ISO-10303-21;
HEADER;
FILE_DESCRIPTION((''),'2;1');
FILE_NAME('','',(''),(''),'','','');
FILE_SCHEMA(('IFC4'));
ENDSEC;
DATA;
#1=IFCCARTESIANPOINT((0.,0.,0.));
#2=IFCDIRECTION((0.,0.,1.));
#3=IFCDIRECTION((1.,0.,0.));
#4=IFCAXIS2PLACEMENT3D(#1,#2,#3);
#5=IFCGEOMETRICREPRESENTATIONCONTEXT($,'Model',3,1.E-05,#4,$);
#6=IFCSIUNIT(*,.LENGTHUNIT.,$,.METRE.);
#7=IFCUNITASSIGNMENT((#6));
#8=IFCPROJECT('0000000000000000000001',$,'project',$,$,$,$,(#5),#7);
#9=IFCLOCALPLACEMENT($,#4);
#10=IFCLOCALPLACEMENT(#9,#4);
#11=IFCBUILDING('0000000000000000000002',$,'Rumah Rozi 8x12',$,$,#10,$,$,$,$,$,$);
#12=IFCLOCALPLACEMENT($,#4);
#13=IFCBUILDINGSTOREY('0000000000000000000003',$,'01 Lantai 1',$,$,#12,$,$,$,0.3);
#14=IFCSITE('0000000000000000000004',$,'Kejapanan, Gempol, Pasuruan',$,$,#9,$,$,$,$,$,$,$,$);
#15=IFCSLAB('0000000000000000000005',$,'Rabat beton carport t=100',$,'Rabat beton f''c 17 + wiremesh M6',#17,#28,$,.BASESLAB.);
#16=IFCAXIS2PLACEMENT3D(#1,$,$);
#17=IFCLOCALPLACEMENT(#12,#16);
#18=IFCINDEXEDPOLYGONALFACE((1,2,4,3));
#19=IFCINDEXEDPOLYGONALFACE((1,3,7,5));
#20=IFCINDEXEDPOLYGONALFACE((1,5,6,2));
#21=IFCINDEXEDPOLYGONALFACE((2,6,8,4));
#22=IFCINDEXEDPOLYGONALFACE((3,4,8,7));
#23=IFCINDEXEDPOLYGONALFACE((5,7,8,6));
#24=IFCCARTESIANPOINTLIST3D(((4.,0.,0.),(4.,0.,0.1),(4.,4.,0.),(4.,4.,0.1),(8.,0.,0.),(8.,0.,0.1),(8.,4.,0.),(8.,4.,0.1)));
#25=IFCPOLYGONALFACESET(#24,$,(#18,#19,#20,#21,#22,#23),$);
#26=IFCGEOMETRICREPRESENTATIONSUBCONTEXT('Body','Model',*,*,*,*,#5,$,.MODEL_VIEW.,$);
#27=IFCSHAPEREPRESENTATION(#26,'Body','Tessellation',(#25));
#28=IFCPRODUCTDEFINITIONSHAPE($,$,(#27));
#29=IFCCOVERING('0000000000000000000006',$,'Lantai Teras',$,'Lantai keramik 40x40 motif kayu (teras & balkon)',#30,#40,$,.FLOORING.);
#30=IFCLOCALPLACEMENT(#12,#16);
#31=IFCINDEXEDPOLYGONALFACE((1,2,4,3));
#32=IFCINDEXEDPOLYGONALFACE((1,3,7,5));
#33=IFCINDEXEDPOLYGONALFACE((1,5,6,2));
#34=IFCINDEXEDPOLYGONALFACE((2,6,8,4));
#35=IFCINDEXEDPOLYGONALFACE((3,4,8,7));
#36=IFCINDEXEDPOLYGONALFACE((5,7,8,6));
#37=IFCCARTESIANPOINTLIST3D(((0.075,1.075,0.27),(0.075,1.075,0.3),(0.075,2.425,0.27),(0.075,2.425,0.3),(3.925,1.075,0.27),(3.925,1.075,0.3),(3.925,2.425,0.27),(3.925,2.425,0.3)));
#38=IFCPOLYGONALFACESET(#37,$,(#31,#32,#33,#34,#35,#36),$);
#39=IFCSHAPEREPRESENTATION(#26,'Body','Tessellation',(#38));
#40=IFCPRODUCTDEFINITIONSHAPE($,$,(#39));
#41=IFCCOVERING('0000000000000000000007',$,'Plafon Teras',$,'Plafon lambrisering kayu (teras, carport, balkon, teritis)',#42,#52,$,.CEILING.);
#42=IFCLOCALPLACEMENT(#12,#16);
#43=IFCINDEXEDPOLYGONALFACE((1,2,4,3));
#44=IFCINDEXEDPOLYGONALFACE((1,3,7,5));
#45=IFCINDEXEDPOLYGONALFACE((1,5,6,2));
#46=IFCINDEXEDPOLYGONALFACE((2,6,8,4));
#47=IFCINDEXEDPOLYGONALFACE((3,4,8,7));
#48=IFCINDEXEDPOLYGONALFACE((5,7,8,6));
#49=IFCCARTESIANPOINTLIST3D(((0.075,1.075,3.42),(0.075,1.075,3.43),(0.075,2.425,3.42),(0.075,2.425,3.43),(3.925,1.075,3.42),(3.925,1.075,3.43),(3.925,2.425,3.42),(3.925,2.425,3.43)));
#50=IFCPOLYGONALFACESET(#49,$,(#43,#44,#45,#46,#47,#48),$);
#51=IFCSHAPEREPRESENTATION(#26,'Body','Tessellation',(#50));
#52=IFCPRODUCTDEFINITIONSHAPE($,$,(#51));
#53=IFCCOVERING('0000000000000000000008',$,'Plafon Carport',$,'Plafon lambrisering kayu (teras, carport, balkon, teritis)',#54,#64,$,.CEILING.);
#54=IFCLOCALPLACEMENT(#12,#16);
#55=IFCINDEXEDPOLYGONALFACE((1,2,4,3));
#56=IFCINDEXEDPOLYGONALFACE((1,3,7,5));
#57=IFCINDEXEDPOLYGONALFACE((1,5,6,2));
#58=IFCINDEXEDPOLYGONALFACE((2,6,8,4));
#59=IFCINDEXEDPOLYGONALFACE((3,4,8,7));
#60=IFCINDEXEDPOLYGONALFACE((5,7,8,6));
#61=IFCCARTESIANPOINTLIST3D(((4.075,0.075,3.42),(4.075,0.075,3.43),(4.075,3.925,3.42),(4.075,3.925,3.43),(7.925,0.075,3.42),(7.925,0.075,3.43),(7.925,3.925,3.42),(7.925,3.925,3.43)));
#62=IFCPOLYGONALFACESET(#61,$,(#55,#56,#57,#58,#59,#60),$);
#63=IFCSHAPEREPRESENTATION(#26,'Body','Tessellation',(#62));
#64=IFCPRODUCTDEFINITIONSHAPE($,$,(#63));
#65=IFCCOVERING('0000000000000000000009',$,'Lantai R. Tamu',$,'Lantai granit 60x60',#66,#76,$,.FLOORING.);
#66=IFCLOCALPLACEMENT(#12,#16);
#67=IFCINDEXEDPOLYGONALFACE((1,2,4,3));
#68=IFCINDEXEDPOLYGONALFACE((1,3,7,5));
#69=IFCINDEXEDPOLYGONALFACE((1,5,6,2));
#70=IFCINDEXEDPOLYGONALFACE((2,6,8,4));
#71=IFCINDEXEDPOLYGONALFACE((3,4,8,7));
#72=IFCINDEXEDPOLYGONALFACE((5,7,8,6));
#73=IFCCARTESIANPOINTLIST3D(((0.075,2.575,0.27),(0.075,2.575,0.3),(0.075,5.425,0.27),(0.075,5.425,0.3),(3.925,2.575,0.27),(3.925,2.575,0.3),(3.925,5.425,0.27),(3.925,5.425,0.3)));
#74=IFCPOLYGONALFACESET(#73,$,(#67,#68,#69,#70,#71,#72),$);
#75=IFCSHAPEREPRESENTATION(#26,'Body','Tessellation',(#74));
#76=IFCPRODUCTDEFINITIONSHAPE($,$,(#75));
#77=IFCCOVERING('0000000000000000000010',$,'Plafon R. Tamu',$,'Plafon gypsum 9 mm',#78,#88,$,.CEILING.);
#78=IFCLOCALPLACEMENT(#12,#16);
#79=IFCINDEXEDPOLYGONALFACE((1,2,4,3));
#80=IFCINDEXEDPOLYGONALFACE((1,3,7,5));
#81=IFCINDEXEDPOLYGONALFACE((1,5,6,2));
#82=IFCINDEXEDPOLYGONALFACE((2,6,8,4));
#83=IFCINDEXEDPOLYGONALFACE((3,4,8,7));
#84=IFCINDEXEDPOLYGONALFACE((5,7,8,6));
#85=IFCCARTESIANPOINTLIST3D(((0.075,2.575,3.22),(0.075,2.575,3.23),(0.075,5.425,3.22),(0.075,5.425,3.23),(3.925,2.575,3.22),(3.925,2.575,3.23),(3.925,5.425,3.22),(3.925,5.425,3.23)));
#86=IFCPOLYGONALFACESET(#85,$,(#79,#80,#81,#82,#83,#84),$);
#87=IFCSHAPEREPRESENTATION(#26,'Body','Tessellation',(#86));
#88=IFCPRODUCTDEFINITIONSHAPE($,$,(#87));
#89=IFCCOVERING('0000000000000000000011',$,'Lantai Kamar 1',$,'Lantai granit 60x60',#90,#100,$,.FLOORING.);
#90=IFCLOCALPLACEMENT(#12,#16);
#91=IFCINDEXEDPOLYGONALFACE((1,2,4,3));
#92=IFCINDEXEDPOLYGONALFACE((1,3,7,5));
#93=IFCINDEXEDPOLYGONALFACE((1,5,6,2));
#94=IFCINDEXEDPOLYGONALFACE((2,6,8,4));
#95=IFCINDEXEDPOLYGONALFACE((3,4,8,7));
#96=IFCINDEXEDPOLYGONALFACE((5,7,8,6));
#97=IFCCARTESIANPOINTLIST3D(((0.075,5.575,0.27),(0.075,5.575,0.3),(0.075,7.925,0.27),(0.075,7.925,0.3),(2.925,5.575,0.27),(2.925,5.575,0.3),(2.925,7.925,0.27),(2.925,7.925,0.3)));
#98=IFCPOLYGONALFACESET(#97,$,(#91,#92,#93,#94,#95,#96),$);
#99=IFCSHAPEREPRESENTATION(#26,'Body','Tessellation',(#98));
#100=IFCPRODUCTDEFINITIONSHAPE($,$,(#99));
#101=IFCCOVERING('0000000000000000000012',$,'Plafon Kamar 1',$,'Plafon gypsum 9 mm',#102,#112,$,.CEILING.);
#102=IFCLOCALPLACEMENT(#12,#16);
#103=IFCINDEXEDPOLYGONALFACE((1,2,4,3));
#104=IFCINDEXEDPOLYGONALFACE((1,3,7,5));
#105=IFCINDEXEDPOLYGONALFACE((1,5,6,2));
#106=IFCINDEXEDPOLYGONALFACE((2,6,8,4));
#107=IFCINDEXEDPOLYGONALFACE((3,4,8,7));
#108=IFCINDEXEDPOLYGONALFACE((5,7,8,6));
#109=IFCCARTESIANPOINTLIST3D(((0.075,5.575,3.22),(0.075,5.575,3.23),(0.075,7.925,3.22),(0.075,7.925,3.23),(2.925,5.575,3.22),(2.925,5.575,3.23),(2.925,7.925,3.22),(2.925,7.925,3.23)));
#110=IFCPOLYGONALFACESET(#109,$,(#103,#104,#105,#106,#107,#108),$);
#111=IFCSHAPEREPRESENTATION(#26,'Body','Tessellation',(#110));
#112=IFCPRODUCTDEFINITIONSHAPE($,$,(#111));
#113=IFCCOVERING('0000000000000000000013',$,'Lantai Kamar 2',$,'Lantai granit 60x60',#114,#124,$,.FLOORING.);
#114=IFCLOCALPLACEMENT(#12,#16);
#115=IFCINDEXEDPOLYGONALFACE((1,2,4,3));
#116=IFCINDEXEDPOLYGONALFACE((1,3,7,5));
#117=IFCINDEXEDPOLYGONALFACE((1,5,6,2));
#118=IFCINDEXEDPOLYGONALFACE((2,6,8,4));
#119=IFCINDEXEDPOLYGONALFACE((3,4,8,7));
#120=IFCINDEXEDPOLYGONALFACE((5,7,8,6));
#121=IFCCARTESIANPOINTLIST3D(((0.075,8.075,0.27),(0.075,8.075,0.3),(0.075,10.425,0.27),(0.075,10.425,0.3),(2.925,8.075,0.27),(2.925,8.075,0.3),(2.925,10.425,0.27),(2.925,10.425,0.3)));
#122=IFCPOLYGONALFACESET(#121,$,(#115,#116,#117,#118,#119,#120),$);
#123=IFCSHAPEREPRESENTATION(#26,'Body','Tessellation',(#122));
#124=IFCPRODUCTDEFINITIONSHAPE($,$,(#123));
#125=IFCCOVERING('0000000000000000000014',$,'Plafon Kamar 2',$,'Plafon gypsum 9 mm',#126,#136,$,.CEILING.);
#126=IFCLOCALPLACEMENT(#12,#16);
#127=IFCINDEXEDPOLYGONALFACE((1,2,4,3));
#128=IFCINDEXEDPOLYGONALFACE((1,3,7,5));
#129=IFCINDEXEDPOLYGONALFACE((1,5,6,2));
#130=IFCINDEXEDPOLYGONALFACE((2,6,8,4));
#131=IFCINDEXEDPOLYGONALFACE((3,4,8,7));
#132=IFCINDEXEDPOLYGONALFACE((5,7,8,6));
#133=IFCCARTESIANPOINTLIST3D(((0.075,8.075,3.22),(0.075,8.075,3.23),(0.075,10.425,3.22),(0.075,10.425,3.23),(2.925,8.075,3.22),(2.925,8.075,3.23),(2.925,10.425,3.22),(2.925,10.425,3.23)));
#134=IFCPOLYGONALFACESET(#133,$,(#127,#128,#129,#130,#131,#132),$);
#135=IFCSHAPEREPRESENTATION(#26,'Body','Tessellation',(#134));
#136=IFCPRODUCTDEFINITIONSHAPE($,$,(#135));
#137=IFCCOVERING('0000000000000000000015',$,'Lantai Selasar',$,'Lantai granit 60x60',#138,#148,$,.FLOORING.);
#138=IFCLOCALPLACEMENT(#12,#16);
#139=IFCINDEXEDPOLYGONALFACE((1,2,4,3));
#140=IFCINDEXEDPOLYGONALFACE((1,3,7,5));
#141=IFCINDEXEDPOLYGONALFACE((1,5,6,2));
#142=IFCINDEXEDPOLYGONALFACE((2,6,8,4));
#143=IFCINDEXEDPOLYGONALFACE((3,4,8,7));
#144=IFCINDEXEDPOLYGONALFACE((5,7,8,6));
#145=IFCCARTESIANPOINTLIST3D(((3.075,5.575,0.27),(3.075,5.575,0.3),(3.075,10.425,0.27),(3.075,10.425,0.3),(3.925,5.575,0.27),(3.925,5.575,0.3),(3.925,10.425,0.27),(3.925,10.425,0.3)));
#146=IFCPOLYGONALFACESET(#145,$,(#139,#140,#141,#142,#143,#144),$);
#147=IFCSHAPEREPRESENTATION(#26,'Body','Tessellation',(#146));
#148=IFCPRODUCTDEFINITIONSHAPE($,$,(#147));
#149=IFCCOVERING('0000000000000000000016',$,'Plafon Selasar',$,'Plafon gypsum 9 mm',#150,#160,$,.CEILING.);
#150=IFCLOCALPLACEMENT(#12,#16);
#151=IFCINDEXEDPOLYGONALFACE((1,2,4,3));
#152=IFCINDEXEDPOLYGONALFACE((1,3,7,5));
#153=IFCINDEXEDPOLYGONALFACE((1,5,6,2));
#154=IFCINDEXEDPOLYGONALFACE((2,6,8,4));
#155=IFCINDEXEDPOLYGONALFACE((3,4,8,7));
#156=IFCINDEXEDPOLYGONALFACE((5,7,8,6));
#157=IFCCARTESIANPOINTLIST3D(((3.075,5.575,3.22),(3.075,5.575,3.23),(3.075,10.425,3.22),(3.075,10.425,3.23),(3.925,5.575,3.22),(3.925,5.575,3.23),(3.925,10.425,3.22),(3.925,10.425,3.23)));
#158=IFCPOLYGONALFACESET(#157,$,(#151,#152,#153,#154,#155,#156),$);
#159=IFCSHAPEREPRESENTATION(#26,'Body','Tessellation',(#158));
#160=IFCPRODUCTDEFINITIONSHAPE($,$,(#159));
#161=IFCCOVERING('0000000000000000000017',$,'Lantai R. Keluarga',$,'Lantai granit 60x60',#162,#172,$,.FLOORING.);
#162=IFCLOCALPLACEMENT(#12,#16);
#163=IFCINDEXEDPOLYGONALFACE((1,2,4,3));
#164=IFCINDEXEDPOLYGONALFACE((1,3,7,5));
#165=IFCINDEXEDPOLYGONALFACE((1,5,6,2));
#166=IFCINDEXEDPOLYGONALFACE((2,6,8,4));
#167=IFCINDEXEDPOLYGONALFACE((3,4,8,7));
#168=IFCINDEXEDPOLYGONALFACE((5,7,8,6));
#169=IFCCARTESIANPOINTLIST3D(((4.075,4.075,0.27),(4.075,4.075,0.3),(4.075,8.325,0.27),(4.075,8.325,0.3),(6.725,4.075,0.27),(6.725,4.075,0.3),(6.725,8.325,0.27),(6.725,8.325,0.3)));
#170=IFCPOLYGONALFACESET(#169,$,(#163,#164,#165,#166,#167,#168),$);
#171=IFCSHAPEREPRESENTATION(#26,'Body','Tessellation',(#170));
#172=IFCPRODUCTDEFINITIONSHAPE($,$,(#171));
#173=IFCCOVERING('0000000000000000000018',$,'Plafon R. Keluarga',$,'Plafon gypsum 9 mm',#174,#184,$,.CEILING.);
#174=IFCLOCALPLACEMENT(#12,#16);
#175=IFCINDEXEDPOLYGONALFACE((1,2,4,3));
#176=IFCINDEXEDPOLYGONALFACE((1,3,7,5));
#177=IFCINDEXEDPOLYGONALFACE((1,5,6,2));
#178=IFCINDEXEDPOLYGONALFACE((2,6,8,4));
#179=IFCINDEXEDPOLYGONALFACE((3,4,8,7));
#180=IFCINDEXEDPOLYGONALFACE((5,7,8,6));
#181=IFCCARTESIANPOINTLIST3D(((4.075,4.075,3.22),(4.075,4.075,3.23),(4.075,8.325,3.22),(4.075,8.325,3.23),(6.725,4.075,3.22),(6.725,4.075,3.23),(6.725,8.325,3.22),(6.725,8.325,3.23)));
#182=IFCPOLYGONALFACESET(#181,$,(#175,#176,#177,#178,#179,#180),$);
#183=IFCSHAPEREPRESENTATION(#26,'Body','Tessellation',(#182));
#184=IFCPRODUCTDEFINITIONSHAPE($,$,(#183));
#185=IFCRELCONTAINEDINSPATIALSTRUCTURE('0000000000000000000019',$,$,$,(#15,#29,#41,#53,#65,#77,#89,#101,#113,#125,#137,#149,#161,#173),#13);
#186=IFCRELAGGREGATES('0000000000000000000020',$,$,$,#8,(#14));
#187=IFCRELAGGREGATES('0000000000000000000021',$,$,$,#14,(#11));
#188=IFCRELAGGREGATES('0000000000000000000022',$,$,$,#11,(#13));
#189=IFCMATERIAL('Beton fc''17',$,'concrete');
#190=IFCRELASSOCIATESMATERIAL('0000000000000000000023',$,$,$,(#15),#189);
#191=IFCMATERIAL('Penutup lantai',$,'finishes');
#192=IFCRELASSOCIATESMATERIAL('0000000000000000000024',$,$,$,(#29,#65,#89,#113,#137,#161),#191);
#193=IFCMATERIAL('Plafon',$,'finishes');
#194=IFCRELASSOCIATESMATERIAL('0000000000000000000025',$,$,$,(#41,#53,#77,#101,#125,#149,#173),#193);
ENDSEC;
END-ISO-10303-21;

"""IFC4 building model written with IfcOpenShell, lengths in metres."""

from ifc_helpers import new_model, si_unit, frame, origin_with_axes, place, context, subcontext, project, spatial, line, indexed_curve, outline, extrude, material, element, save


model = new_model("IFC4")

# Units and contexts
model_context = context("Model", 3, precision=1e-05, world=origin_with_axes())
body_context = subcontext(model_context, "Body", "Model", "MODEL_VIEW")
ifc_project = project(units=[si_unit("LENGTHUNIT", "METRE")], contexts=[model_context])

# Site, building, storey
site_placement = place(None, origin_with_axes())
site = spatial("IfcSite", under=ifc_project, at=site_placement, Name="Kejapanan, Gempol, Pasuruan")
building_placement = place(site_placement, origin_with_axes())
building = spatial("IfcBuilding", under=site, at=building_placement, Name="Rumah Rozi 8x12")
storey_placement = place(None, origin_with_axes())
storey = spatial("IfcBuildingStorey", under=building, at=storey_placement, Name="01 Lantai 1", Elevation=0.3)

# Slab
ifc_material_1 = material(Name="Beton fc'17", Category="concrete")
slab_placement = place(storey_placement, origin_with_axes())
element("IfcSlab", 1, at=slab_placement, inside=storey, material=ifc_material_1, Name="Rabat beton carport t=100", ObjectType="Rabat beton f'c 17 + wiremesh M6", PredefinedType="BASESLAB", context=body_context, shape_type="SweptSolid", body=[
    extrude(outline(indexed_curve([(4.0, 0.0), (8.0, 0.0), (8.0, 4.0), (4.0, 4.0)], segments=[line(1, 2, 3, 4, 1)])), origin_with_axes(), (0.0, 0.0, 1.0), 0.1),
])

# Coverings
ifc_material_2 = material(Name="Penutup lantai", Category="finishes")
covering_1_placement = place(storey_placement, origin_with_axes())
element("IfcCovering", 2, at=covering_1_placement, inside=storey, material=ifc_material_2, Name="Lantai Teras", ObjectType="Lantai keramik 40x40 motif kayu (teras & balkon)", PredefinedType="FLOORING", context=body_context, shape_type="SweptSolid", body=[
    extrude(outline(indexed_curve([(0.075, 1.075), (3.925, 1.075), (3.925, 2.425), (0.075, 2.425)], segments=[line(1, 2, 3, 4, 1)])), frame((0.0, 0.0, 0.27), z_axis=(0.0, 0.0, 1.0), x_axis=(1.0, 0.0, 0.0)), (0.0, 0.0, 1.0), 0.03),
])
ifc_material_3 = material(Name="Plafon", Category="finishes")
covering_2_placement = place(storey_placement, origin_with_axes())
element("IfcCovering", 3, at=covering_2_placement, inside=storey, material=ifc_material_3, Name="Plafon Teras", ObjectType="Plafon lambrisering kayu (teras, carport, balkon, teritis)", PredefinedType="CEILING", context=body_context, shape_type="SweptSolid", body=[
    extrude(outline(indexed_curve([(0.075, 1.075), (3.925, 1.075), (3.925, 2.425), (0.075, 2.425)], segments=[line(1, 2, 3, 4, 1)])), frame((0.0, 0.0, 3.42), z_axis=(0.0, 0.0, 1.0), x_axis=(1.0, 0.0, 0.0)), (0.0, 0.0, 1.0), 0.01),
])
covering_3_placement = place(storey_placement, origin_with_axes())
element("IfcCovering", 4, at=covering_3_placement, inside=storey, material=ifc_material_3, Name="Plafon Carport", ObjectType="Plafon lambrisering kayu (teras, carport, balkon, teritis)", PredefinedType="CEILING", context=body_context, shape_type="SweptSolid", body=[
    extrude(outline(indexed_curve([(4.075, 0.075), (7.925, 0.075), (7.925, 3.925), (4.075, 3.925)], segments=[line(1, 2, 3, 4, 1)])), frame((0.0, 0.0, 3.42), z_axis=(0.0, 0.0, 1.0), x_axis=(1.0, 0.0, 0.0)), (0.0, 0.0, 1.0), 0.01),
])
covering_4_placement = place(storey_placement, origin_with_axes())
element("IfcCovering", 5, at=covering_4_placement, inside=storey, material=ifc_material_2, Name="Lantai R. Tamu", ObjectType="Lantai granit 60x60", PredefinedType="FLOORING", context=body_context, shape_type="SweptSolid", body=[
    extrude(outline(indexed_curve([(0.075, 2.575), (3.925, 2.575), (3.925, 5.425), (0.075, 5.425)], segments=[line(1, 2, 3, 4, 1)])), frame((0.0, 0.0, 0.27), z_axis=(0.0, 0.0, 1.0), x_axis=(1.0, 0.0, 0.0)), (0.0, 0.0, 1.0), 0.03),
])
covering_5_placement = place(storey_placement, origin_with_axes())
element("IfcCovering", 6, at=covering_5_placement, inside=storey, material=ifc_material_3, Name="Plafon R. Tamu", ObjectType="Plafon gypsum 9 mm", PredefinedType="CEILING", context=body_context, shape_type="SweptSolid", body=[
    extrude(outline(indexed_curve([(0.075, 2.575), (3.925, 2.575), (3.925, 5.425), (0.075, 5.425)], segments=[line(1, 2, 3, 4, 1)])), frame((0.0, 0.0, 3.22), z_axis=(0.0, 0.0, 1.0), x_axis=(1.0, 0.0, 0.0)), (0.0, 0.0, 1.0), 0.01),
])
covering_6_placement = place(storey_placement, origin_with_axes())
element("IfcCovering", 7, at=covering_6_placement, inside=storey, material=ifc_material_2, Name="Lantai Kamar 1", ObjectType="Lantai granit 60x60", PredefinedType="FLOORING", context=body_context, shape_type="SweptSolid", body=[
    extrude(outline(indexed_curve([(0.075, 5.575), (2.925, 5.575), (2.925, 7.925), (0.075, 7.925)], segments=[line(1, 2, 3, 4, 1)])), frame((0.0, 0.0, 0.27), z_axis=(0.0, 0.0, 1.0), x_axis=(1.0, 0.0, 0.0)), (0.0, 0.0, 1.0), 0.03),
])
covering_7_placement = place(storey_placement, origin_with_axes())
element("IfcCovering", 8, at=covering_7_placement, inside=storey, material=ifc_material_3, Name="Plafon Kamar 1", ObjectType="Plafon gypsum 9 mm", PredefinedType="CEILING", context=body_context, shape_type="SweptSolid", body=[
    extrude(outline(indexed_curve([(0.075, 5.575), (2.925, 5.575), (2.925, 7.925), (0.075, 7.925)], segments=[line(1, 2, 3, 4, 1)])), frame((0.0, 0.0, 3.22), z_axis=(0.0, 0.0, 1.0), x_axis=(1.0, 0.0, 0.0)), (0.0, 0.0, 1.0), 0.01),
])
covering_8_placement = place(storey_placement, origin_with_axes())
element("IfcCovering", 9, at=covering_8_placement, inside=storey, material=ifc_material_2, Name="Lantai Kamar 2", ObjectType="Lantai granit 60x60", PredefinedType="FLOORING", context=body_context, shape_type="SweptSolid", body=[
    extrude(outline(indexed_curve([(0.075, 8.075), (2.925, 8.075), (2.925, 10.425), (0.075, 10.425)], segments=[line(1, 2, 3, 4, 1)])), frame((0.0, 0.0, 0.27), z_axis=(0.0, 0.0, 1.0), x_axis=(1.0, 0.0, 0.0)), (0.0, 0.0, 1.0), 0.03),
])
covering_9_placement = place(storey_placement, origin_with_axes())
element("IfcCovering", 10, at=covering_9_placement, inside=storey, material=ifc_material_3, Name="Plafon Kamar 2", ObjectType="Plafon gypsum 9 mm", PredefinedType="CEILING", context=body_context, shape_type="SweptSolid", body=[
    extrude(outline(indexed_curve([(0.075, 8.075), (2.925, 8.075), (2.925, 10.425), (0.075, 10.425)], segments=[line(1, 2, 3, 4, 1)])), frame((0.0, 0.0, 3.22), z_axis=(0.0, 0.0, 1.0), x_axis=(1.0, 0.0, 0.0)), (0.0, 0.0, 1.0), 0.01),
])
covering_10_placement = place(storey_placement, origin_with_axes())
element("IfcCovering", 11, at=covering_10_placement, inside=storey, material=ifc_material_2, Name="Lantai Selasar", ObjectType="Lantai granit 60x60", PredefinedType="FLOORING", context=body_context, shape_type="SweptSolid", body=[
    extrude(outline(indexed_curve([(3.075, 5.575), (3.925, 5.575), (3.925, 10.425), (3.075, 10.425)], segments=[line(1, 2, 3, 4, 1)])), frame((0.0, 0.0, 0.27), z_axis=(0.0, 0.0, 1.0), x_axis=(1.0, 0.0, 0.0)), (0.0, 0.0, 1.0), 0.03),
])
covering_11_placement = place(storey_placement, origin_with_axes())
element("IfcCovering", 12, at=covering_11_placement, inside=storey, material=ifc_material_3, Name="Plafon Selasar", ObjectType="Plafon gypsum 9 mm", PredefinedType="CEILING", context=body_context, shape_type="SweptSolid", body=[
    extrude(outline(indexed_curve([(3.075, 5.575), (3.925, 5.575), (3.925, 10.425), (3.075, 10.425)], segments=[line(1, 2, 3, 4, 1)])), frame((0.0, 0.0, 3.22), z_axis=(0.0, 0.0, 1.0), x_axis=(1.0, 0.0, 0.0)), (0.0, 0.0, 1.0), 0.01),
])
covering_12_placement = place(storey_placement, origin_with_axes())
element("IfcCovering", 13, at=covering_12_placement, inside=storey, material=ifc_material_2, Name="Lantai R. Keluarga", ObjectType="Lantai granit 60x60", PredefinedType="FLOORING", context=body_context, shape_type="SweptSolid", body=[
    extrude(outline(indexed_curve([(4.075, 4.075), (6.725, 4.075), (6.725, 8.325), (4.075, 8.325)], segments=[line(1, 2, 3, 4, 1)])), frame((0.0, 0.0, 0.27), z_axis=(0.0, 0.0, 1.0), x_axis=(1.0, 0.0, 0.0)), (0.0, 0.0, 1.0), 0.03),
])
covering_13_placement = place(storey_placement, origin_with_axes())
element("IfcCovering", 14, at=covering_13_placement, inside=storey, material=ifc_material_3, Name="Plafon R. Keluarga", ObjectType="Plafon gypsum 9 mm", PredefinedType="CEILING", context=body_context, shape_type="SweptSolid", body=[
    extrude(outline(indexed_curve([(4.075, 4.075), (6.725, 4.075), (6.725, 8.325), (4.075, 8.325)], segments=[line(1, 2, 3, 4, 1)])), frame((0.0, 0.0, 3.22), z_axis=(0.0, 0.0, 1.0), x_axis=(1.0, 0.0, 0.0)), (0.0, 0.0, 1.0), 0.01),
])

save(model, "model.ifc")
